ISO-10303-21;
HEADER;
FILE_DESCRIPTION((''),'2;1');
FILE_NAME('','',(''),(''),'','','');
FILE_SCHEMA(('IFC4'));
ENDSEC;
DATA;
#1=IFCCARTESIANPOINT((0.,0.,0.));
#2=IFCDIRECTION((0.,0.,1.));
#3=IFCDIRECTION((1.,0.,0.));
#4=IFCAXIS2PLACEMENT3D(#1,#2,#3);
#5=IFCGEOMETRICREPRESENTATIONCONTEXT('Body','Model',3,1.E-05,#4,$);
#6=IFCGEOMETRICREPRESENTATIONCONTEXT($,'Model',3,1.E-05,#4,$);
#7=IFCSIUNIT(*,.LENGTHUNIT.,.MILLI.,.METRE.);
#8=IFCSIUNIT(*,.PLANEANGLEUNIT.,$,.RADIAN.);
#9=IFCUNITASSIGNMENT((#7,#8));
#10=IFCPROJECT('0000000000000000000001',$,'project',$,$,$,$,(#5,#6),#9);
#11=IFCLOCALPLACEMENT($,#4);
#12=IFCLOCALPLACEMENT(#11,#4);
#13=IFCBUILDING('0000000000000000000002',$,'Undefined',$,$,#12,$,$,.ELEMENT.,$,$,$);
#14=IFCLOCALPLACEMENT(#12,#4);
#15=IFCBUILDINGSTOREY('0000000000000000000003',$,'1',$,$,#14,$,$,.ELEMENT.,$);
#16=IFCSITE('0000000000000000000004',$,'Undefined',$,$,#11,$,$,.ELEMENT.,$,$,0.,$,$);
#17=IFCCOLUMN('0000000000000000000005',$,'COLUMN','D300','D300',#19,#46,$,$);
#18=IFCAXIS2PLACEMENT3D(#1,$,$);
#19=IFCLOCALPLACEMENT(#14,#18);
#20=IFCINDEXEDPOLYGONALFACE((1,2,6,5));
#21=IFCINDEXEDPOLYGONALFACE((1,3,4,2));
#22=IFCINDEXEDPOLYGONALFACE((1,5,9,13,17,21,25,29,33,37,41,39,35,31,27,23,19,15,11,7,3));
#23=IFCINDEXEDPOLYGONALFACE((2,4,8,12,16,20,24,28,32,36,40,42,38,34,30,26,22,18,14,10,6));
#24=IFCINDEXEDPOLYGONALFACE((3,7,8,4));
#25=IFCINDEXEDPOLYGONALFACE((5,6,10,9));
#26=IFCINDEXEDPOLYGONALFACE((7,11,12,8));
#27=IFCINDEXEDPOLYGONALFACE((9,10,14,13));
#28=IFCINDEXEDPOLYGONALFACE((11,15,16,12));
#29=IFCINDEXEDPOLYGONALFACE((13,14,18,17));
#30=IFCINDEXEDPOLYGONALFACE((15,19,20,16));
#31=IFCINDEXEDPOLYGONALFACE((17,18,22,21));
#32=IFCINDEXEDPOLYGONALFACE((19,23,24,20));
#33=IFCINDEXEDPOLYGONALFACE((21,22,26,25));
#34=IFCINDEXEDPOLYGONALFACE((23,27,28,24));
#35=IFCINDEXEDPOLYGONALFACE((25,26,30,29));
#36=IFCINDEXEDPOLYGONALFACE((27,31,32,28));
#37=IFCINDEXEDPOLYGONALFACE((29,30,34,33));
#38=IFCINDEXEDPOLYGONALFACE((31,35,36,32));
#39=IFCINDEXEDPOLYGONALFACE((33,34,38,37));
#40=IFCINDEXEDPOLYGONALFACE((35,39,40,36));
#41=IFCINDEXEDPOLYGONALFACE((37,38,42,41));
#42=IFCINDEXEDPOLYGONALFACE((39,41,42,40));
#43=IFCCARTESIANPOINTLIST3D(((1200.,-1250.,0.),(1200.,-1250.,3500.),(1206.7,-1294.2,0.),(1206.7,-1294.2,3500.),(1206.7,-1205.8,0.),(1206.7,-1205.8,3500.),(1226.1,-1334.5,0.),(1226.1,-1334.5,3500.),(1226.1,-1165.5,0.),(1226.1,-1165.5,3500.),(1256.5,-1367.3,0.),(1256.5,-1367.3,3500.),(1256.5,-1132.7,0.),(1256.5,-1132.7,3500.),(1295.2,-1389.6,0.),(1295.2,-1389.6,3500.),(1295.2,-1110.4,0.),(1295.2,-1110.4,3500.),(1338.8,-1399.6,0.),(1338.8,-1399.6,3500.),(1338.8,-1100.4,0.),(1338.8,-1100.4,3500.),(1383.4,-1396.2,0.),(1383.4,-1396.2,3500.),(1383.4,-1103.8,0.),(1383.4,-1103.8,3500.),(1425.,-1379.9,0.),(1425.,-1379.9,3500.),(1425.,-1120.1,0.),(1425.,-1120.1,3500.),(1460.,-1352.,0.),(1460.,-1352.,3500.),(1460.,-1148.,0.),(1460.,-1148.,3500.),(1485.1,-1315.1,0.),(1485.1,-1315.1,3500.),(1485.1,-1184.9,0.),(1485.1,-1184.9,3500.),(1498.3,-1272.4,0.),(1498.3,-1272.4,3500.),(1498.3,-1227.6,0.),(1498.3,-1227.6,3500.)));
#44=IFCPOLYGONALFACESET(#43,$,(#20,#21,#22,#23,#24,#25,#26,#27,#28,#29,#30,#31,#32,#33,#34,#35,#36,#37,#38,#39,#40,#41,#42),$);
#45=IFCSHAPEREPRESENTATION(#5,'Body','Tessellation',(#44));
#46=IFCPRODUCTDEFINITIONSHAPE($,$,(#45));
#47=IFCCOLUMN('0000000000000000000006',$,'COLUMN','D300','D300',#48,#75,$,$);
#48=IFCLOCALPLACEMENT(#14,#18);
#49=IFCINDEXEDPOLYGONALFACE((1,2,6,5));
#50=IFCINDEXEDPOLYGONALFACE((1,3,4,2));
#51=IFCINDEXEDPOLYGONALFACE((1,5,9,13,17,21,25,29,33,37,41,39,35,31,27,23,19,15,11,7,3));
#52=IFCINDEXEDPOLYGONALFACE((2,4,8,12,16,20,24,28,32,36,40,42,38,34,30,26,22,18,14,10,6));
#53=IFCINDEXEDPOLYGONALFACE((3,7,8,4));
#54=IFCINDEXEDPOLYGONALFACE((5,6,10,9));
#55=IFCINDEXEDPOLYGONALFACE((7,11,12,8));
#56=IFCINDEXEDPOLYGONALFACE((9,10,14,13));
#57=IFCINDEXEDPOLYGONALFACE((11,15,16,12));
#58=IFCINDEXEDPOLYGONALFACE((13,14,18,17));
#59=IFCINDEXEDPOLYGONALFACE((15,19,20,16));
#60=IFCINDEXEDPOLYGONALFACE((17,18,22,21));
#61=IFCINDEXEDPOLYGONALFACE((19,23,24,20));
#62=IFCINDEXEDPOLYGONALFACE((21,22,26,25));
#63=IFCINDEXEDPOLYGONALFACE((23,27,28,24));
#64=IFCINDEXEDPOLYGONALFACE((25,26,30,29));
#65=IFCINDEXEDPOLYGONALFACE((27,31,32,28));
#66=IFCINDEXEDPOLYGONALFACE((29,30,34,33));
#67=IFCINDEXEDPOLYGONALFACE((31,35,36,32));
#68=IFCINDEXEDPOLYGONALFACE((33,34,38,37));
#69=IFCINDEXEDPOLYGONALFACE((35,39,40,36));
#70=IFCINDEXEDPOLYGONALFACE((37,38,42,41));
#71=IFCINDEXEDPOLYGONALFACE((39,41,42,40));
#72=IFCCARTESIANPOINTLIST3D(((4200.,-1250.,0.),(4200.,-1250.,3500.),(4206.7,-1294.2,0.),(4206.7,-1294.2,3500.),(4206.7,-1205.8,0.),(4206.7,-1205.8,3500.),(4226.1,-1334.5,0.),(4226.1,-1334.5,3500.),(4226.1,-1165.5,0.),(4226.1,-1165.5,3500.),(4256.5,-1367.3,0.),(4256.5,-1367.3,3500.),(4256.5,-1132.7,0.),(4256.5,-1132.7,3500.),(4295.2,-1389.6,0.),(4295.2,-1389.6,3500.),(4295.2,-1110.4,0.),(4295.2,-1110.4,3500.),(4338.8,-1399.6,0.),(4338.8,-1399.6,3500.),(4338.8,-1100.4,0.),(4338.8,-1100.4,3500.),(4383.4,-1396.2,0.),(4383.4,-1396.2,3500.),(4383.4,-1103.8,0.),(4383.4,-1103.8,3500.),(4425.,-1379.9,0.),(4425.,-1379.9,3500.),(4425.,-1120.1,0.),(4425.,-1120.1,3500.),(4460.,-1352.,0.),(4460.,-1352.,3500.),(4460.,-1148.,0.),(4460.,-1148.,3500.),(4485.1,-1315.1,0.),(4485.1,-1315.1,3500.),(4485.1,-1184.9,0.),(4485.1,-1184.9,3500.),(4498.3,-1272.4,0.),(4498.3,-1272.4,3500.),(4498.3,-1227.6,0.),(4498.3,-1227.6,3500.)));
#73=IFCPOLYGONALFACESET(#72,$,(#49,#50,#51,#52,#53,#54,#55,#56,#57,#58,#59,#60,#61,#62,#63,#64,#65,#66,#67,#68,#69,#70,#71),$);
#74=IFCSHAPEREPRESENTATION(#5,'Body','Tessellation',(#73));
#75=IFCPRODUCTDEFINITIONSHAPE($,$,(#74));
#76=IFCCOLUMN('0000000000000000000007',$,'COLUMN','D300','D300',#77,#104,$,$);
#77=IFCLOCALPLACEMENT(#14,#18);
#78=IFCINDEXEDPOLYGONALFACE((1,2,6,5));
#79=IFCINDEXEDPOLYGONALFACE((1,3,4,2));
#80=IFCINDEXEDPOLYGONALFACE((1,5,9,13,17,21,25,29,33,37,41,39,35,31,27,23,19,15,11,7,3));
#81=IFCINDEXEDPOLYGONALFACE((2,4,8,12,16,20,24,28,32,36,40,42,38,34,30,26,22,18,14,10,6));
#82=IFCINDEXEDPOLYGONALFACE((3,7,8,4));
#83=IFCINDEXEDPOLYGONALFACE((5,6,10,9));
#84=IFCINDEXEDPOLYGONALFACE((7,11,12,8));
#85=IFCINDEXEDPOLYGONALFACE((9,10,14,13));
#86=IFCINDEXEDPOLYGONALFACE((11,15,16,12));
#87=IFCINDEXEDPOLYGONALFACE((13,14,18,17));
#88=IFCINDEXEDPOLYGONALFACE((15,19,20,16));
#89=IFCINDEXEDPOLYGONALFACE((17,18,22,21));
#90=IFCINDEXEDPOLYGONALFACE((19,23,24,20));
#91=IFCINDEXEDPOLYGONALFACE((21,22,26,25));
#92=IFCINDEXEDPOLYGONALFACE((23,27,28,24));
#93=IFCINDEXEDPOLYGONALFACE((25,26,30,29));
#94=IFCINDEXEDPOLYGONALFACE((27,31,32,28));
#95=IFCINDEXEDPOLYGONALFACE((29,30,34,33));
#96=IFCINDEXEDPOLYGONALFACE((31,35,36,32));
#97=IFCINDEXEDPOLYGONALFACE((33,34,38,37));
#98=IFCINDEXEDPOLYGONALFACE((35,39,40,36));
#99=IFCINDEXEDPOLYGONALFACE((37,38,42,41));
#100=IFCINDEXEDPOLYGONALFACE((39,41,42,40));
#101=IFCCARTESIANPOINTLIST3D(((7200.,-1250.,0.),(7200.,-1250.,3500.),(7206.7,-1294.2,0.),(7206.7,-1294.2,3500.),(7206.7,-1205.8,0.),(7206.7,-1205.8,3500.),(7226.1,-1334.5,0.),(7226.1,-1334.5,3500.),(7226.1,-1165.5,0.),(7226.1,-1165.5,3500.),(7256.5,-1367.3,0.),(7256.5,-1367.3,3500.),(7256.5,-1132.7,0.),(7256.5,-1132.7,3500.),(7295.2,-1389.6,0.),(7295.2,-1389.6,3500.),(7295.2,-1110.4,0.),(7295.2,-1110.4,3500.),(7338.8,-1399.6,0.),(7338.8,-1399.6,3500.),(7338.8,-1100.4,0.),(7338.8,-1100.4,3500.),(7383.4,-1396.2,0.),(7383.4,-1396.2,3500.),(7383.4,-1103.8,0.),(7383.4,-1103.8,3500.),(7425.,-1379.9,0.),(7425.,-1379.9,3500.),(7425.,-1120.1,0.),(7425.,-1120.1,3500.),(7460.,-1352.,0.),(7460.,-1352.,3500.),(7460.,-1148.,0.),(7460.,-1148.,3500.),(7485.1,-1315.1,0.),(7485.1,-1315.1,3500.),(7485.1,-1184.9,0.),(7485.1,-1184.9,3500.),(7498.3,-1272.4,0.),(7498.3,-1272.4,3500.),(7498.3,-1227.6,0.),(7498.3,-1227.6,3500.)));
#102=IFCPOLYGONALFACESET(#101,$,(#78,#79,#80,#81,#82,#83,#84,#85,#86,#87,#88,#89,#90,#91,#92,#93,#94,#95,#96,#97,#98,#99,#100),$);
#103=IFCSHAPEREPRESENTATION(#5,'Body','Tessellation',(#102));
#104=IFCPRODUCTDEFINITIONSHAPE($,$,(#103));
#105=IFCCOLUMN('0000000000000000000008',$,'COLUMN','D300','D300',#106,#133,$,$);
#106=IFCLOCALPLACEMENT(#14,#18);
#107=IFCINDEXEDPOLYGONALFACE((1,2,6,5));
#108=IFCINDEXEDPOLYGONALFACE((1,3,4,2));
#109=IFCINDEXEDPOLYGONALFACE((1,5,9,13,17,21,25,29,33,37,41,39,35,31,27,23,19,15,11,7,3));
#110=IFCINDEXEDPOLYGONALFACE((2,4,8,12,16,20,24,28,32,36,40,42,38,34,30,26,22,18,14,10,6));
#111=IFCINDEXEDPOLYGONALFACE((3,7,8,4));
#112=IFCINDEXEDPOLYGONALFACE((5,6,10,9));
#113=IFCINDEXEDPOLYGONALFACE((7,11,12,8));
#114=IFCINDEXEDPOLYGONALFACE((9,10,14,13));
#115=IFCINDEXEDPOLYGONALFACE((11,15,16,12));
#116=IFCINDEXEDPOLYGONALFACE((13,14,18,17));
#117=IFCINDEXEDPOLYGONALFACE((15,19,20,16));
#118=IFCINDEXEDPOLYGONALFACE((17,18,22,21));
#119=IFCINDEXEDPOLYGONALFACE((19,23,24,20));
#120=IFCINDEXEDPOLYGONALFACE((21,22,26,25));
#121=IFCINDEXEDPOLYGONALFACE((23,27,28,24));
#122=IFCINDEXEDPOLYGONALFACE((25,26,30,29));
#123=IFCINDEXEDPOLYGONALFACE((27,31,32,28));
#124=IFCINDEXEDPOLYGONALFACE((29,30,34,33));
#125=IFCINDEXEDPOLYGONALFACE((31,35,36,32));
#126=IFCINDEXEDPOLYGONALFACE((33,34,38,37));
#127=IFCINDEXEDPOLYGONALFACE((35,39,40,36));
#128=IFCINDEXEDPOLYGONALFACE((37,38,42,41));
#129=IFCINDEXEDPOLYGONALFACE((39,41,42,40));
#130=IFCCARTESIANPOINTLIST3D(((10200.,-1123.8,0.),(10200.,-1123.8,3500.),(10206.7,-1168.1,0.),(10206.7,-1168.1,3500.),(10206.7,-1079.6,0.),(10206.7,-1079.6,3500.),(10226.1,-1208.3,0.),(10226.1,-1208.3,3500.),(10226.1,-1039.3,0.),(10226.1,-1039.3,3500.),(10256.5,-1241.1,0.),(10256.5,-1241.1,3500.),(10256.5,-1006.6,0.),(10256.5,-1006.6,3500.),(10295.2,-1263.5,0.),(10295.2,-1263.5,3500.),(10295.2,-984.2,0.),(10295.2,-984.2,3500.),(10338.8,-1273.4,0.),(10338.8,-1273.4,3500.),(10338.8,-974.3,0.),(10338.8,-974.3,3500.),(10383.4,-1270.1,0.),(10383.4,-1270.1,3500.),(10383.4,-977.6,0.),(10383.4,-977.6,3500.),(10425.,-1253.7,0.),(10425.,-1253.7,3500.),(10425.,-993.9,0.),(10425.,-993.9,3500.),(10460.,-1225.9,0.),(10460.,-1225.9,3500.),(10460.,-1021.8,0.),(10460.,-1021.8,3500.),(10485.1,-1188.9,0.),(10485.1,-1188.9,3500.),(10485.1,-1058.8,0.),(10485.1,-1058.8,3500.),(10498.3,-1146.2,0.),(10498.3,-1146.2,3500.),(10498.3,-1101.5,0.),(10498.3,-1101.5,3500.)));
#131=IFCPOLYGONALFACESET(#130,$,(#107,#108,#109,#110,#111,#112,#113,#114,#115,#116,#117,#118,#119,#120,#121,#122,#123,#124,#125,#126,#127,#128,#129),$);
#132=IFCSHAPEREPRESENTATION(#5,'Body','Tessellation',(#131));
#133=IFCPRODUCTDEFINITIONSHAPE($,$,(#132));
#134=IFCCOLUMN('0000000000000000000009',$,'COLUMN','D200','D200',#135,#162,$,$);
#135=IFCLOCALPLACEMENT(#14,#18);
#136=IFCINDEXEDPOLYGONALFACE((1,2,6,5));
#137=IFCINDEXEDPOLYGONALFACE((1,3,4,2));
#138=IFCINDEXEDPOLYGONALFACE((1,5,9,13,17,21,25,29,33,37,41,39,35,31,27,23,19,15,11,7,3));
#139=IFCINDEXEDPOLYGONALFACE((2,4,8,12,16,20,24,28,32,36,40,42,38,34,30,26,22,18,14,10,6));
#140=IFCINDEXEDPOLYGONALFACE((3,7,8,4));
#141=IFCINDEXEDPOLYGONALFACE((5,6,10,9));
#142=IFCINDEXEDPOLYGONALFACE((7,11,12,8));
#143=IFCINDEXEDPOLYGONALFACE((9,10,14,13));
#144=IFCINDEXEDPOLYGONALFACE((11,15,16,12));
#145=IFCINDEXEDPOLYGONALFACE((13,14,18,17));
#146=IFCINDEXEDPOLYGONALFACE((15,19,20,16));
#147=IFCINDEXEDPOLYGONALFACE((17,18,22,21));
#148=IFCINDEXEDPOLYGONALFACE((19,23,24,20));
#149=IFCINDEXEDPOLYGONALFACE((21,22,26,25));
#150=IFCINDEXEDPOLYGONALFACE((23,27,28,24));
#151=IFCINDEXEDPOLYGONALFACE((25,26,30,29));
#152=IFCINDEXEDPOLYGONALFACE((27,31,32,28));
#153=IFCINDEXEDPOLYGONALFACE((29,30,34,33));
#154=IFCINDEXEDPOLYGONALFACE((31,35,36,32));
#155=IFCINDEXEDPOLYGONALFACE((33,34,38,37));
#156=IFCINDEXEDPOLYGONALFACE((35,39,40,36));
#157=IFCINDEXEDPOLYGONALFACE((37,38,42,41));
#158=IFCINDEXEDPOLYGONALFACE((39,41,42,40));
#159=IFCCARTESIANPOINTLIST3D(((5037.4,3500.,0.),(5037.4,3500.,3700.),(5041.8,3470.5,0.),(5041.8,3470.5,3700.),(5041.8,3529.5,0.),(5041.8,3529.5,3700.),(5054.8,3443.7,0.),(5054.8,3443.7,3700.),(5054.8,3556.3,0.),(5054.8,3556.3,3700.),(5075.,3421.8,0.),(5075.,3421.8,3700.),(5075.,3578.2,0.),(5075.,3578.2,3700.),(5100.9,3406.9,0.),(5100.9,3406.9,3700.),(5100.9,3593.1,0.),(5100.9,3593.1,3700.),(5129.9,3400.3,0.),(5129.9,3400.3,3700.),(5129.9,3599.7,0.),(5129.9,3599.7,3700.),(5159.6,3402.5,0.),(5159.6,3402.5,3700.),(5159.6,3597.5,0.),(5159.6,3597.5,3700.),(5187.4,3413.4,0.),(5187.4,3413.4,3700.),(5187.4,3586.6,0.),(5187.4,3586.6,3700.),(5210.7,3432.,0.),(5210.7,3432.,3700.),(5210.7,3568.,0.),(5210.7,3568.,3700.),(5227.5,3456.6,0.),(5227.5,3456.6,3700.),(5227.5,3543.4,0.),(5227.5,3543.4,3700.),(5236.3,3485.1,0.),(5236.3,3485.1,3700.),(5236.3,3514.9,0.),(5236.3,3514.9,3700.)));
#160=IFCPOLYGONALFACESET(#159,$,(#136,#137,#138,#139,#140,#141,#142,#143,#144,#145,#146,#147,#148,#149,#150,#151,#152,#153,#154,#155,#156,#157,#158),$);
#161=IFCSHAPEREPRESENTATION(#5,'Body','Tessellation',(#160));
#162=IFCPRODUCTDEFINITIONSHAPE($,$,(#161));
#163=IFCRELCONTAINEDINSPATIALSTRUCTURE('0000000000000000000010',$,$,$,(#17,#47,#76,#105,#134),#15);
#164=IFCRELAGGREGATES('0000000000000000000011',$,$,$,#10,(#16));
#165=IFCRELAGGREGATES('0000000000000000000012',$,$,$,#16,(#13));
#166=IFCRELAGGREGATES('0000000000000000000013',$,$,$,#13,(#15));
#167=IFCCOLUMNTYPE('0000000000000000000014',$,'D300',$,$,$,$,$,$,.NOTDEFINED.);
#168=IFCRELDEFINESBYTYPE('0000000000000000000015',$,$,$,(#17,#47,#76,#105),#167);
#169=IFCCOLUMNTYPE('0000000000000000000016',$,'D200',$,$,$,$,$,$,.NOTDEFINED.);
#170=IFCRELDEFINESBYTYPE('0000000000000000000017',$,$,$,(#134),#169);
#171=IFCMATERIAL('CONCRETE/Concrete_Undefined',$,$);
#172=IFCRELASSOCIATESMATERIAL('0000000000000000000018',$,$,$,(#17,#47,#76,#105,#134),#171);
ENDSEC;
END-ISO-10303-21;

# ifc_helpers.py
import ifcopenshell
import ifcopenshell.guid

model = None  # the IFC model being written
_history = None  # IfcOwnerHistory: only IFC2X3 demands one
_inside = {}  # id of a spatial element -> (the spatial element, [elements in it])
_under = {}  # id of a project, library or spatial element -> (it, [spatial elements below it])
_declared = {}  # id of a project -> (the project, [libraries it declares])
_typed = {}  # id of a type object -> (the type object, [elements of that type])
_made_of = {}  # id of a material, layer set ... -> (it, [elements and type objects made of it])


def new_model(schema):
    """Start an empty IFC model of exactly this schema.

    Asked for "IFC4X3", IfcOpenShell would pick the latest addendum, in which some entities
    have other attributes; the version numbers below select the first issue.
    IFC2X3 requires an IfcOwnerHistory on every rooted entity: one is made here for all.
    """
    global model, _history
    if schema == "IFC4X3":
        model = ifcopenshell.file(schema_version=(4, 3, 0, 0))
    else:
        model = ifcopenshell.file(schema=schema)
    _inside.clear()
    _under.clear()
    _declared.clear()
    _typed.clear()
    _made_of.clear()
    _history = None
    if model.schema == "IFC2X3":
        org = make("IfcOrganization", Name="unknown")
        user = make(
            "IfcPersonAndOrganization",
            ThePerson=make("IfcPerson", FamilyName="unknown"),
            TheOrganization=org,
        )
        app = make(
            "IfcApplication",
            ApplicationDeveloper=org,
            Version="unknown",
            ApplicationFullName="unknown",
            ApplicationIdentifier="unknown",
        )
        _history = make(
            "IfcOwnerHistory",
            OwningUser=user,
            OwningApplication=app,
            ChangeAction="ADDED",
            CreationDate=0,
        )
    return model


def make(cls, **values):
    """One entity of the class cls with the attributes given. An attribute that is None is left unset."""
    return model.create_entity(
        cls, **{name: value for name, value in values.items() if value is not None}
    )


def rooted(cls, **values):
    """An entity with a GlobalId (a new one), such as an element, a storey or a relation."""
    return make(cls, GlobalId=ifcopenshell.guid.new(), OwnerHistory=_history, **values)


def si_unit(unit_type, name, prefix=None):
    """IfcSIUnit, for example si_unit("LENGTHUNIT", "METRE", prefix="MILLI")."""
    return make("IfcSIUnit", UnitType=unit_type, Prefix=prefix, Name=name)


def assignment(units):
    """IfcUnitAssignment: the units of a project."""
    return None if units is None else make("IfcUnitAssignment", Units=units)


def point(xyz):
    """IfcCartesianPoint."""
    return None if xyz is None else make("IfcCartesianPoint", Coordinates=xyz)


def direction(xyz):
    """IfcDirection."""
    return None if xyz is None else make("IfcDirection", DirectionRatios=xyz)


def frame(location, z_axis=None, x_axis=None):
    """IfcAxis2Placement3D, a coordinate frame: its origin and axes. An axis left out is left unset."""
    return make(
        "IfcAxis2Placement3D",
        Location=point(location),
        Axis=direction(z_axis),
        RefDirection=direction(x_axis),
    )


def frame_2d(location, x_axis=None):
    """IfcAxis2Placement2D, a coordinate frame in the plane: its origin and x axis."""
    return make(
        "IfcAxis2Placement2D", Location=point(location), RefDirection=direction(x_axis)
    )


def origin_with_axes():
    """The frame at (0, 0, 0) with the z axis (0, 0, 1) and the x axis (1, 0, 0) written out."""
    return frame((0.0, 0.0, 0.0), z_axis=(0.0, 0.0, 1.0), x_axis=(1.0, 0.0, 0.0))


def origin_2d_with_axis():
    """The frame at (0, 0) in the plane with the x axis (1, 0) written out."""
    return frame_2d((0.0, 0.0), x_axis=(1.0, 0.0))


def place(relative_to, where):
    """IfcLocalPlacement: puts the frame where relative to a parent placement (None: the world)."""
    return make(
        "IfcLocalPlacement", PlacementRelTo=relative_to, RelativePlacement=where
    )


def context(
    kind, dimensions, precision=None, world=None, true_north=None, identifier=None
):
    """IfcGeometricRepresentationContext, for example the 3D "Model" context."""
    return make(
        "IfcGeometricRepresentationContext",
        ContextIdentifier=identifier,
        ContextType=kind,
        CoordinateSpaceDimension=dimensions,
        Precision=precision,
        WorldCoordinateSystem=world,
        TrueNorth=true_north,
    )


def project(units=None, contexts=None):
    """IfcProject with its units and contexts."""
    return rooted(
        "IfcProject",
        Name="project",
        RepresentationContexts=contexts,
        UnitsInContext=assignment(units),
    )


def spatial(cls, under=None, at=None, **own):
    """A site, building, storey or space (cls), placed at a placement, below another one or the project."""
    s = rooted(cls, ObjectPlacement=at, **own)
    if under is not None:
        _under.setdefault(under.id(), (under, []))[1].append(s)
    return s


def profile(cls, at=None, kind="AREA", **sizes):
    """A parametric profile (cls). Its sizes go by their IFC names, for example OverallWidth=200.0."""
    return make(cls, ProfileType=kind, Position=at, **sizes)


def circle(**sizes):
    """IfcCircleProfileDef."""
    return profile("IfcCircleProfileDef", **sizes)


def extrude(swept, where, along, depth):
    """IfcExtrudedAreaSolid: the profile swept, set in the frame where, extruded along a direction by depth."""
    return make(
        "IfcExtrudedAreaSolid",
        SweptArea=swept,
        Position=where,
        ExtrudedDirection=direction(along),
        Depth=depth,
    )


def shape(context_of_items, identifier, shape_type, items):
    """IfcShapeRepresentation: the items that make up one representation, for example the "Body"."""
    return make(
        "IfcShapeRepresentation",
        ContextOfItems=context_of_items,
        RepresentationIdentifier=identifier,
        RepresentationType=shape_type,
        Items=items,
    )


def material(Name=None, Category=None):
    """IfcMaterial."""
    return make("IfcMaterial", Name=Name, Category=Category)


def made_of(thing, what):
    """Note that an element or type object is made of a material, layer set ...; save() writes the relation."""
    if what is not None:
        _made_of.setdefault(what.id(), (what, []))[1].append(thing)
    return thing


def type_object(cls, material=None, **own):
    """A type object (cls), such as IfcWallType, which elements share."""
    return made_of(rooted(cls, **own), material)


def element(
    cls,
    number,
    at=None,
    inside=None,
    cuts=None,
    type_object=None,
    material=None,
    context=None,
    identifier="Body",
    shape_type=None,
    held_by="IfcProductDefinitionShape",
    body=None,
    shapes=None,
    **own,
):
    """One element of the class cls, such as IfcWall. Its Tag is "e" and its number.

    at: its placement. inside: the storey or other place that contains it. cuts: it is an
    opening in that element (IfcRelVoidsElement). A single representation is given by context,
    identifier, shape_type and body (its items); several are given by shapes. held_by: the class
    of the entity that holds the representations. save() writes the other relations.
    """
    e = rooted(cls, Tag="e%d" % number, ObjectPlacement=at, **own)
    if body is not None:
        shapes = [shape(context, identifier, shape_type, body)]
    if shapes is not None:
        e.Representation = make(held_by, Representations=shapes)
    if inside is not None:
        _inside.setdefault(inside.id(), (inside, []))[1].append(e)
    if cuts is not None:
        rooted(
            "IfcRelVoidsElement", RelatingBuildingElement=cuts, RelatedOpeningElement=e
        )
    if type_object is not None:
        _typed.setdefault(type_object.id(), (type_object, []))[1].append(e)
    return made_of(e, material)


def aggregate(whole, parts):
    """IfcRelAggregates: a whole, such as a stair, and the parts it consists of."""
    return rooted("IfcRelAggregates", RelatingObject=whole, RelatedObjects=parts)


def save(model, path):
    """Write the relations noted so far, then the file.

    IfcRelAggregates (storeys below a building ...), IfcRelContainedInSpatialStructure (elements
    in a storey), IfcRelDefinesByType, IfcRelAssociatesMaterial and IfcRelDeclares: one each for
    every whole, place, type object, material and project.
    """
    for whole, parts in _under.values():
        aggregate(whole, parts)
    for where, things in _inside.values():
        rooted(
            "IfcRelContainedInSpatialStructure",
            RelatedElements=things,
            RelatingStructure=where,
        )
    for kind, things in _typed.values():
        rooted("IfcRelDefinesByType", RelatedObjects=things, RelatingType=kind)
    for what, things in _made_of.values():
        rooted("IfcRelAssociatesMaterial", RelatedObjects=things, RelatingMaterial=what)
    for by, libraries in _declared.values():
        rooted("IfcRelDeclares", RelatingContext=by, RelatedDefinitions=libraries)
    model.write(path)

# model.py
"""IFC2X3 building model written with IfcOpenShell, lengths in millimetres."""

from ifc_helpers import new_model, si_unit, frame, origin_with_axes, origin_2d_with_axis, place, context, project, spatial, circle, extrude, material, type_object, element, save


model = new_model("IFC2X3")

# Units and contexts
model_context_1 = context("Model", 3, precision=1e-05, world=origin_with_axes(), identifier="Body")
model_context_2 = context("Model", 3, precision=1e-05, world=origin_with_axes())
ifc_project = project(units=[si_unit("LENGTHUNIT", "METRE", prefix="MILLI"), si_unit("PLANEANGLEUNIT", "RADIAN")], contexts=[model_context_1, model_context_2])

# Site, building, storey
site_placement = place(None, origin_with_axes())
site = spatial("IfcSite", under=ifc_project, at=site_placement, Name="Undefined", CompositionType="ELEMENT", RefElevation=0.0)
building_placement = place(site_placement, origin_with_axes())
building = spatial("IfcBuilding", under=site, at=building_placement, Name="Undefined", CompositionType="ELEMENT")
storey_placement = place(building_placement, origin_with_axes())
storey = spatial("IfcBuildingStorey", under=building, at=storey_placement, Name="1", CompositionType="ELEMENT")

# Columns
ifc_material = material(Name="CONCRETE/Concrete_Undefined")
column_type_1 = type_object("IfcColumnType", Name="D300", PredefinedType="NOTDEFINED")
for number, where, z_axis, x_axis, name in (
    (1, (1350.0, -1250.0, 0.0), (0.0, 0.0, 1.0), (1.0, 0.0, 0.0), "COLUMN"),
    (2, (4350.0, -1250.0, 0.0), (0.0, 0.0, 1.0), (1.0, 0.0, 0.0), "COLUMN"),
    (3, (7350.0, -1250.0, 0.0), (0.0, 0.0, 1.0), (1.0, 0.0, 0.0), "COLUMN"),
    (4, (10350.0, -1123.8, 0.0), (0.0, 0.0, 1.0), (1.0, 0.0, 0.0), "COLUMN"),
):
    element("IfcColumn", number, at=place(storey_placement, frame(where, z_axis=z_axis, x_axis=x_axis)), inside=storey, type_object=column_type_1, material=ifc_material, Name=name, Description="D300", ObjectType="D300", context=model_context_1, shape_type="SweptSolid", body=[
        extrude(circle(Radius=150.0, at=origin_2d_with_axis()), frame((0.0, 0.0, 3500.0), z_axis=(0.0, 0.0, -1.0), x_axis=(-1.0, 0.0, 0.0)), (0.0, 0.0, 1.0), 3500.0),
    ])
column_type_2 = type_object("IfcColumnType", Name="D200", PredefinedType="NOTDEFINED")
column_placement = place(storey_placement, frame((5137.4, 3500.0, 0.0), z_axis=(0.0, 0.0, 1.0), x_axis=(1.0, 0.0, 0.0)))
element("IfcColumn", 5, at=column_placement, inside=storey, type_object=column_type_2, material=ifc_material, Name="COLUMN", Description="D200", ObjectType="D200", context=model_context_1, shape_type="SweptSolid", body=[
    extrude(circle(Radius=100.0, at=origin_2d_with_axis()), frame((0.0, 0.0, 3700.0), z_axis=(0.0, 0.0, -1.0), x_axis=(-1.0, 0.0, 0.0)), (0.0, 0.0, 1.0), 3700.0),
])

save(model, "model.ifc")
